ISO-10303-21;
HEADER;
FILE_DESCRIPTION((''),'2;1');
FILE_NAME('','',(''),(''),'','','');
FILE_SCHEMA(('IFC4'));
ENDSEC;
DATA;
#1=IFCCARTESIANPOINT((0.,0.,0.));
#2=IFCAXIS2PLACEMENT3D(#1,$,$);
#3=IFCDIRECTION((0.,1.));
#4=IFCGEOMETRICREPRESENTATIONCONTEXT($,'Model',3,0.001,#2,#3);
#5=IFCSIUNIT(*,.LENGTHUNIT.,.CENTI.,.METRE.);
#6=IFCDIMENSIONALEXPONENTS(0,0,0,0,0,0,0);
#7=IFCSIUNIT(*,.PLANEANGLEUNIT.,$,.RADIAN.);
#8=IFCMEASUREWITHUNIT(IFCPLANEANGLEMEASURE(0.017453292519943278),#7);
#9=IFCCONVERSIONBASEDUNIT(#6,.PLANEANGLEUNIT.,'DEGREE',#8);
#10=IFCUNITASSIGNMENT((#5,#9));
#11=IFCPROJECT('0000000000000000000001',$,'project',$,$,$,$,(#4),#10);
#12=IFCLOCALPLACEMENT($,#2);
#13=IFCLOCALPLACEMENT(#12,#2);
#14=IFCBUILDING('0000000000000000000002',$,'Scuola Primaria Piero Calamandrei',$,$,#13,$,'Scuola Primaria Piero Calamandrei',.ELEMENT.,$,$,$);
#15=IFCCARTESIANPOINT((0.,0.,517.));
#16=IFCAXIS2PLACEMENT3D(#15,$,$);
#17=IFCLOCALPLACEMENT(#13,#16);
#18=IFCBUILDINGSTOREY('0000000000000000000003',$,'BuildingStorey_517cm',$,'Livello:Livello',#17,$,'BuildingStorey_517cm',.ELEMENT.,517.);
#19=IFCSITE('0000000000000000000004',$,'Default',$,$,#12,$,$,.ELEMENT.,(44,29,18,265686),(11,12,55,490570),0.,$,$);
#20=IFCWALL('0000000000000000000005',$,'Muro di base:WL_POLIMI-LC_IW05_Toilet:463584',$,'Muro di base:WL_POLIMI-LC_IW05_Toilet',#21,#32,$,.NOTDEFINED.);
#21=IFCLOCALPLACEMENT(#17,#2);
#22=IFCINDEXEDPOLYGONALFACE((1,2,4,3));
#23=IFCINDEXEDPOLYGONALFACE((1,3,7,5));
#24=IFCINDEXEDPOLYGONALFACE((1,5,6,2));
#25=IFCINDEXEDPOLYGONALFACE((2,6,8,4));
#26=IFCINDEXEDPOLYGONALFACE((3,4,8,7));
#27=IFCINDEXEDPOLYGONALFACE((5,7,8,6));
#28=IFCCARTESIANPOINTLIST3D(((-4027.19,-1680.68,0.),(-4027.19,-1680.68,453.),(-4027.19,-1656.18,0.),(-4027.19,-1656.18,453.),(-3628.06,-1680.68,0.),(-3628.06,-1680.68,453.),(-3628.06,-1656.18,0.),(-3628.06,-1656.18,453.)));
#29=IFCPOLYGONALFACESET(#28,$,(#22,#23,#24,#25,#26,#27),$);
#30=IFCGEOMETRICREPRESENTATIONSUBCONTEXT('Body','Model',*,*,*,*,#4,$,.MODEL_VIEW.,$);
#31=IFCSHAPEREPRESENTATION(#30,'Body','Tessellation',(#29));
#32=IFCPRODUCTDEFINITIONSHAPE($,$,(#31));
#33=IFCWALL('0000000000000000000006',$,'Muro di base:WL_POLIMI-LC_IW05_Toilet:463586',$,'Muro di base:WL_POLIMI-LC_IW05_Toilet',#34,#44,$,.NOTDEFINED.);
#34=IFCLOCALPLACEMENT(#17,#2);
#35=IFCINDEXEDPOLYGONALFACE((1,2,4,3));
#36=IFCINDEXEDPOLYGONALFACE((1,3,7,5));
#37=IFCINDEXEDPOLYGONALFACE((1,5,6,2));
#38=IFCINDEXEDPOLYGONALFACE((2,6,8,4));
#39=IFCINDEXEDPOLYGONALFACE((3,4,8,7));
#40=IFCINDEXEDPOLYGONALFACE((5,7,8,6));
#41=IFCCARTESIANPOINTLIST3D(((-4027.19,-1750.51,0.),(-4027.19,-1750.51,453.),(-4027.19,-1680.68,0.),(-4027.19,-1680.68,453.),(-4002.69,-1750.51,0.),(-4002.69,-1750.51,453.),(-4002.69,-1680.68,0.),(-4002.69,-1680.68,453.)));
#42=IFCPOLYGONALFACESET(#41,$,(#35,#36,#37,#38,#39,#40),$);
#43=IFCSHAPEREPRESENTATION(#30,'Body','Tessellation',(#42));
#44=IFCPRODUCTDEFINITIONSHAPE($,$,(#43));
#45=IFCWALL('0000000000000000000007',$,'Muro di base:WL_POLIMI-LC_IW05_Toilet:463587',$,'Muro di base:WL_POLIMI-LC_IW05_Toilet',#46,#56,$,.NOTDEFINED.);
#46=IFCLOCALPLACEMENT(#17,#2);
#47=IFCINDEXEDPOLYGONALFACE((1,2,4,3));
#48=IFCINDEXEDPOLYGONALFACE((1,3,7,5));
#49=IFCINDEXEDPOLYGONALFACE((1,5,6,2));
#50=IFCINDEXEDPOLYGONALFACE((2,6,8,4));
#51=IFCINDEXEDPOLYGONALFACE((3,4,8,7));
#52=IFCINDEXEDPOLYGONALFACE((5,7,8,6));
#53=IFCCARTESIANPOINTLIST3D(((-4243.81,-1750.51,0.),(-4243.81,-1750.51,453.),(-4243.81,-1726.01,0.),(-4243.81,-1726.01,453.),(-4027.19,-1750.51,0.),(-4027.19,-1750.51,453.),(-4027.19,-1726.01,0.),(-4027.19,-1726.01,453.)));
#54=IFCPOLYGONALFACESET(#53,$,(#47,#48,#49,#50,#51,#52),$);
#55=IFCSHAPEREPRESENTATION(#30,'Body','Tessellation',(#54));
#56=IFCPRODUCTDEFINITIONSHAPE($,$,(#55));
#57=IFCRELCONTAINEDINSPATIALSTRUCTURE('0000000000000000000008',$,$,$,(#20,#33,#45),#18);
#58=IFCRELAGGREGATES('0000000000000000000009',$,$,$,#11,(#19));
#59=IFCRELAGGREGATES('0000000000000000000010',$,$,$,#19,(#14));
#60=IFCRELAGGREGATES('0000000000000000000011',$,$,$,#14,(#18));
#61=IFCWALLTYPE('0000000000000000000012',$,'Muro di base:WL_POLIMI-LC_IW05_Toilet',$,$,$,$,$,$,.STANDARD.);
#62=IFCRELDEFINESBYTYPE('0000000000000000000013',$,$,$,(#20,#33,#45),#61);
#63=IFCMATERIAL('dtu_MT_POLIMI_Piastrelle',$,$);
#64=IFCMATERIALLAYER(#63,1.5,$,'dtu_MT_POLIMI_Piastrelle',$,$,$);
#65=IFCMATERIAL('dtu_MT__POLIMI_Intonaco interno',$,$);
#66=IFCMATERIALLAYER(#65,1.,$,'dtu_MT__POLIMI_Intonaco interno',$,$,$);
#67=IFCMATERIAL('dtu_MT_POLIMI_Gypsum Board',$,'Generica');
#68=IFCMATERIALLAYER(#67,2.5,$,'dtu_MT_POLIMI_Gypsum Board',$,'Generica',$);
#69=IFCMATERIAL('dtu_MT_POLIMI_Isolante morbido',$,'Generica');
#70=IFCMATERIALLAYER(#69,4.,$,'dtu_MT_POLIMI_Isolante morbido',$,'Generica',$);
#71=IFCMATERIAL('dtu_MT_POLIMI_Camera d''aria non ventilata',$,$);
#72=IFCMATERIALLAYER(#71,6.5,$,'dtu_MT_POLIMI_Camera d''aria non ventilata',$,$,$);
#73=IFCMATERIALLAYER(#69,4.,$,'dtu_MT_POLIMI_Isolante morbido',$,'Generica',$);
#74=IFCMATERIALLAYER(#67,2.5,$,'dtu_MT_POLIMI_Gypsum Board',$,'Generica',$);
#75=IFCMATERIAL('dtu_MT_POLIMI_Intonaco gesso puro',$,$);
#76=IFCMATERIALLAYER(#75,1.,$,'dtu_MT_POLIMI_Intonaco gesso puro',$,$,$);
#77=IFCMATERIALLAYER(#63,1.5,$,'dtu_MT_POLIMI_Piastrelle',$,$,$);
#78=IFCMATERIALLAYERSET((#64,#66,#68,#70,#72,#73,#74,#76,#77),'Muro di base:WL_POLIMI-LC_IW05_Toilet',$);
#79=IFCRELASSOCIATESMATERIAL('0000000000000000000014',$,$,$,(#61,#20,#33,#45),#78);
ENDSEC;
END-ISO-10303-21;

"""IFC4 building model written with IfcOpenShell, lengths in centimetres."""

from ifc_helpers import new_model, entity, si_unit, converted_unit, direction, frame, frame_2d, origin, place, context, subcontext, project, spatial, rectangle, extrude, material, layer, layer_set, layer_usage, type_object, element, save


model = new_model("IFC4")

# Units and contexts
model_context = context("Model", 3, precision=0.001, world=origin(), true_north=direction((0.0, 1.0)))
body_context = subcontext(model_context, "Body", "Model", "MODEL_VIEW")
ifc_project = project(units=[si_unit("LENGTHUNIT", "METRE", prefix="CENTI"), converted_unit("PLANEANGLEUNIT", "DEGREE", entity("IfcPlaneAngleMeasure", 0.017453292519943278), si_unit("PLANEANGLEUNIT", "RADIAN"), dimensions=[0, 0, 0, 0, 0, 0, 0])], contexts=[model_context])

# Site, building, storey
site_placement = place(None, origin())
site = spatial("IfcSite", under=ifc_project, at=site_placement, Name="Default", CompositionType="ELEMENT", RefLatitude=(44, 29, 18, 265686), RefLongitude=(11, 12, 55, 490570), RefElevation=0.0)
building_placement = place(site_placement, origin())
building = spatial("IfcBuilding", under=site, at=building_placement, Name="Scuola Primaria Piero Calamandrei", LongName="Scuola Primaria Piero Calamandrei", CompositionType="ELEMENT")
storey_placement = place(building_placement, frame((0.0, 0.0, 517.0)))
storey = spatial("IfcBuildingStorey", under=building, at=storey_placement, Name="BuildingStorey_517cm", ObjectType="Livello:Livello", LongName="BuildingStorey_517cm", CompositionType="ELEMENT", Elevation=517.0)

# Shared definitions
ifc_material_1 = material(Name="dtu_MT_POLIMI_Isolante morbido", Category="Generica")
ifc_material_2 = material(Name="dtu_MT_POLIMI_Gypsum Board", Category="Generica")
ifc_material_3 = material(Name="dtu_MT__POLIMI_Intonaco interno")

# Shared definitions
ifc_material_4 = material(Name="dtu_MT_POLIMI_Camera d'aria non ventilata")
ifc_material_5 = material(Name="dtu_MT_POLIMI_Intonaco gesso puro")

# Shared definitions
ifc_material_6 = material(Name="dtu_MT_POLIMI_Piastrelle")

# Walls
ifc_layer_1 = layer(ifc_material_6, 1.5, Name="dtu_MT_POLIMI_Piastrelle")
ifc_layer_2 = layer(ifc_material_3, 1.0, Name="dtu_MT__POLIMI_Intonaco interno")
ifc_layer_3 = layer(ifc_material_2, 2.5, Name="dtu_MT_POLIMI_Gypsum Board", Category="Generica")
ifc_layer_4 = layer(ifc_material_1, 4.0, Name="dtu_MT_POLIMI_Isolante morbido", Category="Generica")
ifc_layer_5 = layer(ifc_material_4, 6.5, Name="dtu_MT_POLIMI_Camera d'aria non ventilata")
ifc_layer_6 = layer(ifc_material_1, 4.0, Name="dtu_MT_POLIMI_Isolante morbido", Category="Generica")
ifc_layer_7 = layer(ifc_material_2, 2.5, Name="dtu_MT_POLIMI_Gypsum Board", Category="Generica")
ifc_layer_8 = layer(ifc_material_5, 1.0, Name="dtu_MT_POLIMI_Intonaco gesso puro")
ifc_layer_9 = layer(ifc_material_6, 1.5, Name="dtu_MT_POLIMI_Piastrelle")
ifc_layer_set_1 = layer_set([ifc_layer_1, ifc_layer_2, ifc_layer_3, ifc_layer_4, ifc_layer_5, ifc_layer_6, ifc_layer_7, ifc_layer_8, ifc_layer_9], Name="Muro di base:WL_POLIMI-LC_IW05_Toilet")
ifc_layer_usage_1 = layer_usage(ifc_layer_set_1, "AXIS2", "NEGATIVE", 12.25)
wall_type_1 = type_object("IfcWallType", Name="Muro di base:WL_POLIMI-LC_IW05_Toilet", PredefinedType="STANDARD", material=ifc_layer_set_1)
wall_1_placement = place(storey_placement, frame((-3628.06, -1668.43, 0.0), z_axis=(0.0, 0.0, 1.0), x_axis=(-1.0, 0.0, 0.0)))
element("IfcWall", 1, at=wall_1_placement, inside=storey, type_object=wall_type_1, material=ifc_layer_usage_1, Name="Muro di base:WL_POLIMI-LC_IW05_Toilet:463584", ObjectType="Muro di base:WL_POLIMI-LC_IW05_Toilet", PredefinedType="NOTDEFINED", context=body_context, shape_type="SweptSolid", body=[
    extrude(rectangle(XDim=399.13, YDim=24.5, at=frame_2d((199.57, 0.0), x_axis=(-1.0, 0.0))), origin(), (0.0, 0.0, 1.0), 453.0),
])
ifc_layer_usage_2 = layer_usage(ifc_layer_set_1, "AXIS2", "NEGATIVE", 12.25)
wall_2_placement = place(storey_placement, frame((-4014.94, -1680.68, 0.0), z_axis=(0.0, 0.0, 1.0), x_axis=(0.0, -1.0, 0.0)))
element("IfcWall", 2, at=wall_2_placement, inside=storey, type_object=wall_type_1, material=ifc_layer_usage_2, Name="Muro di base:WL_POLIMI-LC_IW05_Toilet:463586", ObjectType="Muro di base:WL_POLIMI-LC_IW05_Toilet", PredefinedType="NOTDEFINED", context=body_context, shape_type="SweptSolid", body=[
    extrude(rectangle(XDim=69.83, YDim=24.5, at=frame_2d((34.91, 0.0), x_axis=(-1.0, 0.0))), origin(), (0.0, 0.0, 1.0), 453.0),
])
ifc_layer_usage_3 = layer_usage(ifc_layer_set_1, "AXIS2", "NEGATIVE", 12.25)
wall_3_placement = place(storey_placement, frame((-4027.19, -1738.26, 0.0), z_axis=(0.0, 0.0, 1.0), x_axis=(-1.0, 0.0, 0.0)))
element("IfcWall", 3, at=wall_3_placement, inside=storey, type_object=wall_type_1, material=ifc_layer_usage_3, Name="Muro di base:WL_POLIMI-LC_IW05_Toilet:463587", ObjectType="Muro di base:WL_POLIMI-LC_IW05_Toilet", PredefinedType="NOTDEFINED", context=body_context, shape_type="SweptSolid", body=[
    extrude(rectangle(XDim=216.62, YDim=24.5, at=frame_2d((108.31, 0.0), x_axis=(-1.0, 0.0))), origin(), (0.0, 0.0, 1.0), 453.0),
])

save(model, "model.ifc")
